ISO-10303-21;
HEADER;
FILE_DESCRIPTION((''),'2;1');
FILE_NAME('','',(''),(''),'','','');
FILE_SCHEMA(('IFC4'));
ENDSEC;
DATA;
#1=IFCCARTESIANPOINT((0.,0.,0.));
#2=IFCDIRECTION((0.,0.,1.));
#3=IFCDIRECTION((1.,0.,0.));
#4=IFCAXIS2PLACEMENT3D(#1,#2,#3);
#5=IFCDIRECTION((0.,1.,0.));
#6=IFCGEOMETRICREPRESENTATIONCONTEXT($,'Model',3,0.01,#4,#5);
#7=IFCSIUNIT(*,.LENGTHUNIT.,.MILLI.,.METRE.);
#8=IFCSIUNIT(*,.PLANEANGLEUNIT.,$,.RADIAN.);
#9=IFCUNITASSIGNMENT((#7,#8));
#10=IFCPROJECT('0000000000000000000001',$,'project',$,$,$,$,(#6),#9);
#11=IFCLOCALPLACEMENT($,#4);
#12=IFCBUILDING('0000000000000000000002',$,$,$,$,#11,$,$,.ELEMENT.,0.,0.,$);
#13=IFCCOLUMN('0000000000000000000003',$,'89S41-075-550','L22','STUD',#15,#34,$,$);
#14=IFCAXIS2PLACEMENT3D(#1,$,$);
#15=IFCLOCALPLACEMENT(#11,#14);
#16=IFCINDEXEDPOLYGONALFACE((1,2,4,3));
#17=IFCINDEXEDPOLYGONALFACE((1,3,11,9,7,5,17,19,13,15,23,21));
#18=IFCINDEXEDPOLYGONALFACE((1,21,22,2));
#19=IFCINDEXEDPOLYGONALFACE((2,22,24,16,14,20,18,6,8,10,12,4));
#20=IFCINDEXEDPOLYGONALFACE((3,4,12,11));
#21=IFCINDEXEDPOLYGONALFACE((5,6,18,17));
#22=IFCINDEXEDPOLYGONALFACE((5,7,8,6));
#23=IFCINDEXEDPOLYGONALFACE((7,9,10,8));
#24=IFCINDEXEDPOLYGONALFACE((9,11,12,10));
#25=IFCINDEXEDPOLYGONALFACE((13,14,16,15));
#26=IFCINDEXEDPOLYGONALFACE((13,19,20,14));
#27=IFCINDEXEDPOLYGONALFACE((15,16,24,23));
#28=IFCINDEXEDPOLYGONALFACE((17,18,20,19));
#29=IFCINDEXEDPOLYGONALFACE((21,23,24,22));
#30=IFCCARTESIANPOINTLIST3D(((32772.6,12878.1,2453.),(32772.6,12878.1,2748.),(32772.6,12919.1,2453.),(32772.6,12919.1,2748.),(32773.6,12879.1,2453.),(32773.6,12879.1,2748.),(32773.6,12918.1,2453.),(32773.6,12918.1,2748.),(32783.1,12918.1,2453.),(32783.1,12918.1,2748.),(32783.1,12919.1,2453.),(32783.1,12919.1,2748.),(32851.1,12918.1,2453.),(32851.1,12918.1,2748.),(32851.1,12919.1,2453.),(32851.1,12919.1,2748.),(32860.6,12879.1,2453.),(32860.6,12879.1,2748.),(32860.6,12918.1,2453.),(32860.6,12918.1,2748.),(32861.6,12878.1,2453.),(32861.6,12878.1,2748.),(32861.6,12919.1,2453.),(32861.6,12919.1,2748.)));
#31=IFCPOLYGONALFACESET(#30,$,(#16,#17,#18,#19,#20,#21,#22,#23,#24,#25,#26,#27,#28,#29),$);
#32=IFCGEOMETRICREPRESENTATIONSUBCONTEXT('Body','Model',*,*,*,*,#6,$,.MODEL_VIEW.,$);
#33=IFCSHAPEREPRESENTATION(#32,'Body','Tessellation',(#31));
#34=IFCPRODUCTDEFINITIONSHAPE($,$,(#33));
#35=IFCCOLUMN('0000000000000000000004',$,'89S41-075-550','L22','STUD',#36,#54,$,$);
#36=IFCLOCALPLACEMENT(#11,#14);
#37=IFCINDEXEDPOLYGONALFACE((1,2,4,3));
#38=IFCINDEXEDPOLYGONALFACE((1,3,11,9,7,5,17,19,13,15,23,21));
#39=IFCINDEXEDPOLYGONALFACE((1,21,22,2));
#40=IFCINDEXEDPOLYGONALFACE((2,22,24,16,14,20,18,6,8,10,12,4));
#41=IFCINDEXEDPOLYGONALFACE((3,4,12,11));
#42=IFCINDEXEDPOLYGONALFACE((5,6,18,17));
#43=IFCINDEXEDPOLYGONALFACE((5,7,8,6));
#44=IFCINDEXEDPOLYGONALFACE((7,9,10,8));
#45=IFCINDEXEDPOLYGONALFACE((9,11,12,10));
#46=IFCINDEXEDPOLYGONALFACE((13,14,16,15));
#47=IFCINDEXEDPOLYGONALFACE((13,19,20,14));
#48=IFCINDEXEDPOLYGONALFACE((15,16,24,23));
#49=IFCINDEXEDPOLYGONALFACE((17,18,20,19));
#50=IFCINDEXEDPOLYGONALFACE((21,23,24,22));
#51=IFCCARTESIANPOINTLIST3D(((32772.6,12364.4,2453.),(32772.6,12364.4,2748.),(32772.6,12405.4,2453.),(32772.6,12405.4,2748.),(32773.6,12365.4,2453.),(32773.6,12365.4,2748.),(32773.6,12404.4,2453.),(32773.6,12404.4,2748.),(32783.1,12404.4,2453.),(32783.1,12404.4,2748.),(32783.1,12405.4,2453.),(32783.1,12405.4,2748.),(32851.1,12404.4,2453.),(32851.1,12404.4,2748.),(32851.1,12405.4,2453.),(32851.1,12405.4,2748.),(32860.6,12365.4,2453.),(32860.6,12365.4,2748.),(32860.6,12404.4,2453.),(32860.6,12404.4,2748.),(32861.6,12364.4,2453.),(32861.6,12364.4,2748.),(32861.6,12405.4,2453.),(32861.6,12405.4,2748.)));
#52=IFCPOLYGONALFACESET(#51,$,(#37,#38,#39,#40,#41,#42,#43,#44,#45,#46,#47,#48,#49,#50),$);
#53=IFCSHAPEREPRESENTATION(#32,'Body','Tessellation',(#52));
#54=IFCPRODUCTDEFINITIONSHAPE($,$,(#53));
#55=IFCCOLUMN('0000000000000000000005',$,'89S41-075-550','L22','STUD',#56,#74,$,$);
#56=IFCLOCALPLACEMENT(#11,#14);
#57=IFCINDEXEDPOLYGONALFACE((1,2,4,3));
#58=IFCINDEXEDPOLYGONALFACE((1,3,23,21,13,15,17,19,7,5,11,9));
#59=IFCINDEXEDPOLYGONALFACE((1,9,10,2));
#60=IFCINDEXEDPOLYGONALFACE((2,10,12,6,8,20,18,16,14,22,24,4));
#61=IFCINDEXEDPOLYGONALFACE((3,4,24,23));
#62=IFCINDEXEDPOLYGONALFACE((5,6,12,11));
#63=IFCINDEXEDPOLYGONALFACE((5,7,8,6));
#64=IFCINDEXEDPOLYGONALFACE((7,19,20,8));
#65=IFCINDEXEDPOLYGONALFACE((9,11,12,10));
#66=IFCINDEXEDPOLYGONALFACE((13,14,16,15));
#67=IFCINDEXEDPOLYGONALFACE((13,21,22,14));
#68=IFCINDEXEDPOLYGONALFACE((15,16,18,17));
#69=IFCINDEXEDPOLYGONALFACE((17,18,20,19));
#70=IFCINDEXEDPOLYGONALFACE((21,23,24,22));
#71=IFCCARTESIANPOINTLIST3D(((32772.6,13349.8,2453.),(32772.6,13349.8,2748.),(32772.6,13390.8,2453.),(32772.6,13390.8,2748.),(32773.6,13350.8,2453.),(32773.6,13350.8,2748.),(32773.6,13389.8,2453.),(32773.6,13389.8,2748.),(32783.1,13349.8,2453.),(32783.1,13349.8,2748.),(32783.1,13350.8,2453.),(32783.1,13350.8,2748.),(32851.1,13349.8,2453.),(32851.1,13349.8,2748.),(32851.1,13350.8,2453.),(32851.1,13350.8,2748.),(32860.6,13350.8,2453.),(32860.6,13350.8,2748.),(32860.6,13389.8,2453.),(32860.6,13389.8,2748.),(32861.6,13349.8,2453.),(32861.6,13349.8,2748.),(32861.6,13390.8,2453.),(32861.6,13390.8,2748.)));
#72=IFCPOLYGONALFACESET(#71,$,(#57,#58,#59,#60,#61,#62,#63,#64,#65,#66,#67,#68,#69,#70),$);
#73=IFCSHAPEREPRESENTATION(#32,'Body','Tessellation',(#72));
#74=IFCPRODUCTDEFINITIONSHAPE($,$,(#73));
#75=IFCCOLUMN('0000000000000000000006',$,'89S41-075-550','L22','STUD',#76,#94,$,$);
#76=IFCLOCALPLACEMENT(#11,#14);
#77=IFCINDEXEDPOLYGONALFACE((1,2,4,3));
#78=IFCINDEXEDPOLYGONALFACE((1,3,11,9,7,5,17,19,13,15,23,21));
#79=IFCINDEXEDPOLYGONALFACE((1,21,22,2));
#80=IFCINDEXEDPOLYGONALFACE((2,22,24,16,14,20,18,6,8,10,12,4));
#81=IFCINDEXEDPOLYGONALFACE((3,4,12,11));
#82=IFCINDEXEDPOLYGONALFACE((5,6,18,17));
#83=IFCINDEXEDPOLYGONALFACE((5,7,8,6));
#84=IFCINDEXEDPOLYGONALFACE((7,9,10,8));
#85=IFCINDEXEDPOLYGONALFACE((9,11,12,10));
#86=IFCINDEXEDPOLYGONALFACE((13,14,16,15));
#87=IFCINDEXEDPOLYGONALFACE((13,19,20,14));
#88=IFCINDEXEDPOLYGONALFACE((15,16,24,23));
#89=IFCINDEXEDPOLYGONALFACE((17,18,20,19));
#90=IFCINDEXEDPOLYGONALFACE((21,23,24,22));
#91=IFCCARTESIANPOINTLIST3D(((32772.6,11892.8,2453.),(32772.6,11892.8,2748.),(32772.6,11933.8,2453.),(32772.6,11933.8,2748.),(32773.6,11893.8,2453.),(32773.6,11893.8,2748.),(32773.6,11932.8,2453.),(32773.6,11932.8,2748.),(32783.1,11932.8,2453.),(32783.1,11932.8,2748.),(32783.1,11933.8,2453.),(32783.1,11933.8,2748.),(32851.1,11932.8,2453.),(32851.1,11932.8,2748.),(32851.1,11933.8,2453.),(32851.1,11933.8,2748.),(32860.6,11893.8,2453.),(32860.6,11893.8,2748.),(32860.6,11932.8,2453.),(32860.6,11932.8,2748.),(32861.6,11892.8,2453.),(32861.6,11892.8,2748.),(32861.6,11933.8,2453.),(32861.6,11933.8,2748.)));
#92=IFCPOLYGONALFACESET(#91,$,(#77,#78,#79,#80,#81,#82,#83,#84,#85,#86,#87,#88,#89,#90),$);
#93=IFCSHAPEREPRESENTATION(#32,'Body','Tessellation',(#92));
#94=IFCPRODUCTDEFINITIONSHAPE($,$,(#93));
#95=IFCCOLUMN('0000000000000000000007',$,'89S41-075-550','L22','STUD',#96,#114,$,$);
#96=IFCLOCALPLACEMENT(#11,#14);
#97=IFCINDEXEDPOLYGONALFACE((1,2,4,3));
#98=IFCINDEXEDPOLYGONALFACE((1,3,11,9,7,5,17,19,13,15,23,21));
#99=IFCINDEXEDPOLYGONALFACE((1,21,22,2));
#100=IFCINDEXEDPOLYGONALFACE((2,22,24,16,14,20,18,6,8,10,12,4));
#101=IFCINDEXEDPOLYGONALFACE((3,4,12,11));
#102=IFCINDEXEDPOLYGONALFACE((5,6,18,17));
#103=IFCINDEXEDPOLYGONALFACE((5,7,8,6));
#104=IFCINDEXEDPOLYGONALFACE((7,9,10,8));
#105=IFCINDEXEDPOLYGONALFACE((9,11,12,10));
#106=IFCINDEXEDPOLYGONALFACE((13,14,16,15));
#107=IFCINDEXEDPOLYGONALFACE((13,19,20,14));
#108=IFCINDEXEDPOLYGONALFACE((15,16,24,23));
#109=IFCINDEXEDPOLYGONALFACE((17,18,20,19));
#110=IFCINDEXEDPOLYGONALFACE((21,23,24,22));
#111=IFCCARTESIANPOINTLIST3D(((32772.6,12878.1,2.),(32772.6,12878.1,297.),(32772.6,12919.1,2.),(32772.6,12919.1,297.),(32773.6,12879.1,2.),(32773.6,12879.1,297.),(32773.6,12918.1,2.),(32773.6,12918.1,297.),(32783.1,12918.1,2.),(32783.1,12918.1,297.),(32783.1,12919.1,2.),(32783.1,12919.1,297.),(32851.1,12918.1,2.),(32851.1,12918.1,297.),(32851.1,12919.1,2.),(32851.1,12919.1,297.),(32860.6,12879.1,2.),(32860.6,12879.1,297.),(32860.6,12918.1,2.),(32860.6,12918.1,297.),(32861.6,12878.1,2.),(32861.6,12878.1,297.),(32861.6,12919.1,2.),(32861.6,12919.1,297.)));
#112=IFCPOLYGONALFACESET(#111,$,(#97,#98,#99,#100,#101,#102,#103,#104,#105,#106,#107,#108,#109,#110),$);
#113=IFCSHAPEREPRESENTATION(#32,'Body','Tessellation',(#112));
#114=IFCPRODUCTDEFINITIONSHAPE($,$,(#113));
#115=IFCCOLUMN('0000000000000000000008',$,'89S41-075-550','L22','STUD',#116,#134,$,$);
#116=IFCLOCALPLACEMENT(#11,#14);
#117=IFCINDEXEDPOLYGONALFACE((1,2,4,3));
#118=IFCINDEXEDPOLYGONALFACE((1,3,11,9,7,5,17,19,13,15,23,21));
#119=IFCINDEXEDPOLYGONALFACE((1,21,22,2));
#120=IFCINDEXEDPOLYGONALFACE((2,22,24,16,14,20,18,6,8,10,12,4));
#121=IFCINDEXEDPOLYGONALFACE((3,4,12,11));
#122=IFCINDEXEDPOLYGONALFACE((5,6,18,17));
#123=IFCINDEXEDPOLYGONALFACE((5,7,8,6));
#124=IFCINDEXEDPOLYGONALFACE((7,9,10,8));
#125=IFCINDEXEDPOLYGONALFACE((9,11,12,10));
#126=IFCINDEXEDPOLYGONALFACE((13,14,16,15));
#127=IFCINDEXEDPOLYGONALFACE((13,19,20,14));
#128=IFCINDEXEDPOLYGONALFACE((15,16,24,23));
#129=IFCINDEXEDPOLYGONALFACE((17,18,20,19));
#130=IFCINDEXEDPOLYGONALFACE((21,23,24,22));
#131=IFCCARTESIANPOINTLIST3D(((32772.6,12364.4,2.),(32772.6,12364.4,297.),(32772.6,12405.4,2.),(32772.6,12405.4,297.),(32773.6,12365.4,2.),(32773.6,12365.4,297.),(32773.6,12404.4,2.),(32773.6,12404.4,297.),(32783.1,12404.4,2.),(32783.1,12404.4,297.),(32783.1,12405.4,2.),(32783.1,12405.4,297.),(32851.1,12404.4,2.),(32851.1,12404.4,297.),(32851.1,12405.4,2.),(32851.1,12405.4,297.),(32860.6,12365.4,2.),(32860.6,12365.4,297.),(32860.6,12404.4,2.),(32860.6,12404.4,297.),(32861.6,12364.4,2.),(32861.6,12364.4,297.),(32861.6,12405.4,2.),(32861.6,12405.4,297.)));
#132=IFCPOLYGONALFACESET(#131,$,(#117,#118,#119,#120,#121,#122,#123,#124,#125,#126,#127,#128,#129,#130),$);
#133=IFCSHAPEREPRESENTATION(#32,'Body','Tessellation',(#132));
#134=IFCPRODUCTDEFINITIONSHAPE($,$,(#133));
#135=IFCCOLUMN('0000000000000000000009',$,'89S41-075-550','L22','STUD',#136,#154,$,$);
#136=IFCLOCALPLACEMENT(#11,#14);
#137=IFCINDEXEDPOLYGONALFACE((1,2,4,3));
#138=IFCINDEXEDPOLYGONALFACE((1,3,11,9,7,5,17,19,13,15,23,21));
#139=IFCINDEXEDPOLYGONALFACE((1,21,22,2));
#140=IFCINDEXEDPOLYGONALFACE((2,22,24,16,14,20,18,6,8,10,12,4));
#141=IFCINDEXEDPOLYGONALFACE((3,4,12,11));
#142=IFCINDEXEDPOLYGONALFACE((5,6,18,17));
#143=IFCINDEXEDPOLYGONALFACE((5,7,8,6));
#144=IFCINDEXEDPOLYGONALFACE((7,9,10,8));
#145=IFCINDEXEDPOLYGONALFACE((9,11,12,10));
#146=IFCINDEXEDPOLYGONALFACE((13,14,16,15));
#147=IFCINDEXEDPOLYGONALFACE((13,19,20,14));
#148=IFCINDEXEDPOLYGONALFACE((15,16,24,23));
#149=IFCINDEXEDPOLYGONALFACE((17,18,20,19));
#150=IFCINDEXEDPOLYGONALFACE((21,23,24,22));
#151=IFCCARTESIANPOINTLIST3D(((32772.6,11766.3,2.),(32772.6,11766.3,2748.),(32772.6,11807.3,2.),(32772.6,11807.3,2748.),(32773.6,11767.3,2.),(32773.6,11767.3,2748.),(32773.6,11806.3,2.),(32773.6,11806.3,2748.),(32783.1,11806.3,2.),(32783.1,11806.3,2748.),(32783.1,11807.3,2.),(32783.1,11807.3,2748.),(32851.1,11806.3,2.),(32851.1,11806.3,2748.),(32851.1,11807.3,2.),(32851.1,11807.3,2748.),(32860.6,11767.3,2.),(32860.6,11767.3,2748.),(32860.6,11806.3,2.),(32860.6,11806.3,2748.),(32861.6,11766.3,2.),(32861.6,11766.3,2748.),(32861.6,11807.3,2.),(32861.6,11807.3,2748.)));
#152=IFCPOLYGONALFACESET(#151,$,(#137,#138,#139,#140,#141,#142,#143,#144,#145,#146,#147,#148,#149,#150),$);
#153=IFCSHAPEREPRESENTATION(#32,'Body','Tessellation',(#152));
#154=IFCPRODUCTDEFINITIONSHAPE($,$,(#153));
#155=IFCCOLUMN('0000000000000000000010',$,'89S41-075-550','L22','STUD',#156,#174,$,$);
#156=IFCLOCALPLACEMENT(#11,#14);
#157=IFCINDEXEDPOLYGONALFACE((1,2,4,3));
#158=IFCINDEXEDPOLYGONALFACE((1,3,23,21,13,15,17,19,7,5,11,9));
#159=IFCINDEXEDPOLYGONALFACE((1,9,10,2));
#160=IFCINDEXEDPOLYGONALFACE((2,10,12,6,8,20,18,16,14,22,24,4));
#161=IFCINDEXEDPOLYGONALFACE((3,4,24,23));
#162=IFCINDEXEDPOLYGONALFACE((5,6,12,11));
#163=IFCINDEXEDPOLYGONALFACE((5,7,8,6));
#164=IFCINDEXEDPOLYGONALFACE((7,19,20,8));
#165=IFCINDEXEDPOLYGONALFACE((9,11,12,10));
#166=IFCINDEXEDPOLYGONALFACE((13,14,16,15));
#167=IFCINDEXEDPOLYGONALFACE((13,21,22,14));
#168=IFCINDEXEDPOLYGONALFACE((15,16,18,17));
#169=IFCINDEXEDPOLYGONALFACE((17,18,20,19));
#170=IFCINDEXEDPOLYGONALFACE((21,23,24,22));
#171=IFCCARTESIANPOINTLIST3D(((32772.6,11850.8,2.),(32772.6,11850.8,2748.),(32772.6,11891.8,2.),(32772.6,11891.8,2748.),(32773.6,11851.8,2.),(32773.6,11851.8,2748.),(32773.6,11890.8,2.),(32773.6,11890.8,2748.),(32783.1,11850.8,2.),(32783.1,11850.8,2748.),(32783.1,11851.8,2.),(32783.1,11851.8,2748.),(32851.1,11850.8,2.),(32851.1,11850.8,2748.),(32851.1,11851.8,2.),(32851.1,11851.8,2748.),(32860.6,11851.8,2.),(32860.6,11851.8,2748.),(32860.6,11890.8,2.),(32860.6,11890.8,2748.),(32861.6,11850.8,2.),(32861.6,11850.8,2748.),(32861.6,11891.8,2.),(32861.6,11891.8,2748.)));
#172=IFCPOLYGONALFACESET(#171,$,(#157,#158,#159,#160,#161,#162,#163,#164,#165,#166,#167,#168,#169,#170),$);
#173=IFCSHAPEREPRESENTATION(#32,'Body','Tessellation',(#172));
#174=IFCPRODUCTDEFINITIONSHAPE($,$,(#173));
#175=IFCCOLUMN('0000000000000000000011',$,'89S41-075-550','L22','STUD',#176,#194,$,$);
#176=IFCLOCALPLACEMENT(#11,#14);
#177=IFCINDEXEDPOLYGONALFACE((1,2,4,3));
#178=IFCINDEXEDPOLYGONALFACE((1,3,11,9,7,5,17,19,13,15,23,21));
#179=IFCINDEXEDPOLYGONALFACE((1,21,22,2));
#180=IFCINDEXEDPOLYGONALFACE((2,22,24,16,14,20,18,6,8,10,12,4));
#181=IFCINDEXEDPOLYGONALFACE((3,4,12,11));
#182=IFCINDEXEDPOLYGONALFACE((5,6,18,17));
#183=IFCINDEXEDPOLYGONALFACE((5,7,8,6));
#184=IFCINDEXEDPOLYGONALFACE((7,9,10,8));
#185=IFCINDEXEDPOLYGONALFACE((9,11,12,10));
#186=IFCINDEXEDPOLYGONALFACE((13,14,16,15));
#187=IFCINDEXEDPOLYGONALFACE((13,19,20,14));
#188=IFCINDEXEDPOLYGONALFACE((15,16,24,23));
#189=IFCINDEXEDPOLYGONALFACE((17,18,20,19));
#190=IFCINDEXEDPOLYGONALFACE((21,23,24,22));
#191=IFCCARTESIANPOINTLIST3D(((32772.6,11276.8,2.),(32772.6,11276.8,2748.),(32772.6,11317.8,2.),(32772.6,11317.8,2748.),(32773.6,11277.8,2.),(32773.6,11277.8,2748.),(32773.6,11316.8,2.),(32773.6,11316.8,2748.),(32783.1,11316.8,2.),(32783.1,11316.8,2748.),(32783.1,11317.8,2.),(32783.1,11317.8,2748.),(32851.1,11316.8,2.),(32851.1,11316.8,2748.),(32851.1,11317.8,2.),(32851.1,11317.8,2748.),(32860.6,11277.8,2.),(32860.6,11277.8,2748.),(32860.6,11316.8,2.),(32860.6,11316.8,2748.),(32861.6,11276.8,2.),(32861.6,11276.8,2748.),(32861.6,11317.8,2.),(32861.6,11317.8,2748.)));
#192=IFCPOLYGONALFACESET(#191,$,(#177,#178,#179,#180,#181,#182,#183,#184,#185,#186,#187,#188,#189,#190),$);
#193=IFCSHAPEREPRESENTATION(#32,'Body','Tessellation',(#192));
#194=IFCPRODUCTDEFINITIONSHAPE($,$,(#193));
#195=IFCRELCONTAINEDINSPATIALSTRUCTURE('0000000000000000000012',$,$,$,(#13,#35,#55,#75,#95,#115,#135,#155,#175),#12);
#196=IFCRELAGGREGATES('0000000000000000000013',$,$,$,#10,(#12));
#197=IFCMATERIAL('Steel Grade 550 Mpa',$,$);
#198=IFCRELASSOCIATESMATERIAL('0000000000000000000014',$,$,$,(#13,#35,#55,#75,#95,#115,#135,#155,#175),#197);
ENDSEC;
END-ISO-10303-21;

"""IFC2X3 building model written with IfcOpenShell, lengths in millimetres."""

from ifc_helpers import new_model, si_unit, direction, frame, origin, origin_with_axes, origin_2d_with_axis, place, context, subcontext, project, spatial, c_section, extrude, source, transform, mapped, material, element, save


model = new_model("IFC2X3")

# Units and contexts
model_context = context("Model", 3, precision=0.01, world=origin_with_axes(), true_north=direction((0.0, 1.0, 0.0)))
body_context = subcontext(model_context, "Body", "Model", "MODEL_VIEW")
ifc_project = project(units=[si_unit("LENGTHUNIT", "METRE", prefix="MILLI"), si_unit("PLANEANGLEUNIT", "RADIAN")], contexts=[model_context])

# Building
building_placement = place(None, origin_with_axes())
building = spatial("IfcBuilding", under=ifc_project, at=building_placement, CompositionType="ELEMENT", ElevationOfRefHeight=0.0, ElevationOfTerrain=0.0)

# Columns
ifc_material = material(Name="Steel Grade 550 Mpa")
shared_shape_1 = source(origin(), body_context, "Body", "SweptSolid", [
    extrude(c_section(Depth=89.0, Width=41.0, WallThickness=1.0, Girth=10.5, at=origin_2d_with_axis()), origin_with_axes(), (0.0, 0.0, 1.0), 295.0),
])
column_1_placement = place(None, frame((32817.1, 12898.6, 2453.0), z_axis=(0.0, 0.0, 1.0), x_axis=(0.0, 1.0, 0.0)))
element("IfcColumn", 1, at=column_1_placement, inside=building, material=ifc_material, Name="89S41-075-550", Description="L22", ObjectType="STUD", context=body_context, shape_type="MappedRepresentation", body=[
    mapped(shared_shape_1, transform((0.0, 0.0, 0.0), scale=1.0)),
])
shared_shape_2 = source(origin(), body_context, "Body", "SweptSolid", [
    extrude(c_section(Depth=89.0, Width=41.0, WallThickness=1.0, Girth=10.5, at=origin_2d_with_axis()), origin_with_axes(), (0.0, 0.0, 1.0), 295.0),
])
column_2_placement = place(None, frame((32817.1, 12384.9, 2453.0), z_axis=(0.0, 0.0, 1.0), x_axis=(0.0, 1.0, 0.0)))
element("IfcColumn", 2, at=column_2_placement, inside=building, material=ifc_material, Name="89S41-075-550", Description="L22", ObjectType="STUD", context=body_context, shape_type="MappedRepresentation", body=[
    mapped(shared_shape_2, transform((0.0, 0.0, 0.0), scale=1.0)),
])
shared_shape_3 = source(origin(), body_context, "Body", "SweptSolid", [
    extrude(c_section(Depth=89.0, Width=41.0, WallThickness=1.0, Girth=10.5, at=origin_2d_with_axis()), origin_with_axes(), (0.0, 0.0, 1.0), 295.0),
])
column_3_placement = place(None, frame((32817.1, 13370.3, 2453.0), z_axis=(0.0, 0.0, 1.0), x_axis=(0.0, -1.0, 0.0)))
element("IfcColumn", 3, at=column_3_placement, inside=building, material=ifc_material, Name="89S41-075-550", Description="L22", ObjectType="STUD", context=body_context, shape_type="MappedRepresentation", body=[
    mapped(shared_shape_3, transform((0.0, 0.0, 0.0), scale=1.0)),
])
shared_shape_4 = source(origin(), body_context, "Body", "SweptSolid", [
    extrude(c_section(Depth=89.0, Width=41.0, WallThickness=1.0, Girth=10.5, at=origin_2d_with_axis()), origin_with_axes(), (0.0, 0.0, 1.0), 295.0),
])
column_4_placement = place(None, frame((32817.1, 11913.3, 2453.0), z_axis=(0.0, 0.0, 1.0), x_axis=(0.0, 1.0, 0.0)))
element("IfcColumn", 4, at=column_4_placement, inside=building, material=ifc_material, Name="89S41-075-550", Description="L22", ObjectType="STUD", context=body_context, shape_type="MappedRepresentation", body=[
    mapped(shared_shape_4, transform((0.0, 0.0, 0.0), scale=1.0)),
])
shared_shape_5 = source(origin(), body_context, "Body", "SweptSolid", [
    extrude(c_section(Depth=89.0, Width=41.0, WallThickness=1.0, Girth=10.5, at=origin_2d_with_axis()), origin_with_axes(), (0.0, 0.0, 1.0), 295.0),
])
column_5_placement = place(None, frame((32817.1, 12898.6, 2.0), z_axis=(0.0, 0.0, 1.0), x_axis=(0.0, 1.0, 0.0)))
element("IfcColumn", 5, at=column_5_placement, inside=building, material=ifc_material, Name="89S41-075-550", Description="L22", ObjectType="STUD", context=body_context, shape_type="MappedRepresentation", body=[
    mapped(shared_shape_5, transform((0.0, 0.0, 0.0), scale=1.0)),
])
shared_shape_6 = source(origin(), body_context, "Body", "SweptSolid", [
    extrude(c_section(Depth=89.0, Width=41.0, WallThickness=1.0, Girth=10.5, at=origin_2d_with_axis()), origin_with_axes(), (0.0, 0.0, 1.0), 295.0),
])
column_6_placement = place(None, frame((32817.1, 12384.9, 2.0), z_axis=(0.0, 0.0, 1.0), x_axis=(0.0, 1.0, 0.0)))
element("IfcColumn", 6, at=column_6_placement, inside=building, material=ifc_material, Name="89S41-075-550", Description="L22", ObjectType="STUD", context=body_context, shape_type="MappedRepresentation", body=[
    mapped(shared_shape_6, transform((0.0, 0.0, 0.0), scale=1.0)),
])
shared_shape_7 = source(origin(), body_context, "Body", "SweptSolid", [
    extrude(c_section(Depth=89.0, Width=41.0, WallThickness=1.0, Girth=10.5, at=origin_2d_with_axis()), origin_with_axes(), (0.0, 0.0, 1.0), 2746.0),
])
column_7_placement = place(None, frame((32817.1, 11786.8, 2.0), z_axis=(0.0, 0.0, 1.0), x_axis=(0.0, 1.0, 0.0)))
element("IfcColumn", 7, at=column_7_placement, inside=building, material=ifc_material, Name="89S41-075-550", Description="L22", ObjectType="STUD", context=body_context, shape_type="MappedRepresentation", body=[
    mapped(shared_shape_7, transform((0.0, 0.0, 0.0), scale=1.0)),
])
shared_shape_8 = source(origin(), body_context, "Body", "SweptSolid", [
    extrude(c_section(Depth=89.0, Width=41.0, WallThickness=1.0, Girth=10.5, at=origin_2d_with_axis()), origin_with_axes(), (0.0, 0.0, 1.0), 2746.0),
])
column_8_placement = place(None, frame((32817.1, 11871.3, 2.0), z_axis=(0.0, 0.0, 1.0), x_axis=(0.0, -1.0, 0.0)))
element("IfcColumn", 8, at=column_8_placement, inside=building, material=ifc_material, Name="89S41-075-550", Description="L22", ObjectType="STUD", context=body_context, shape_type="MappedRepresentation", body=[
    mapped(shared_shape_8, transform((0.0, 0.0, 0.0), scale=1.0)),
])
shared_shape_9 = source(origin(), body_context, "Body", "SweptSolid", [
    extrude(c_section(Depth=89.0, Width=41.0, WallThickness=1.0, Girth=10.5, at=origin_2d_with_axis()), origin_with_axes(), (0.0, 0.0, 1.0), 2746.0),
])
column_9_placement = place(None, frame((32817.1, 11297.3, 2.0), z_axis=(0.0, 0.0, 1.0), x_axis=(0.0, 1.0, 0.0)))
element("IfcColumn", 9, at=column_9_placement, inside=building, material=ifc_material, Name="89S41-075-550", Description="L22", ObjectType="STUD", context=body_context, shape_type="MappedRepresentation", body=[
    mapped(shared_shape_9, transform((0.0, 0.0, 0.0), scale=1.0)),
])

save(model, "model.ifc")
